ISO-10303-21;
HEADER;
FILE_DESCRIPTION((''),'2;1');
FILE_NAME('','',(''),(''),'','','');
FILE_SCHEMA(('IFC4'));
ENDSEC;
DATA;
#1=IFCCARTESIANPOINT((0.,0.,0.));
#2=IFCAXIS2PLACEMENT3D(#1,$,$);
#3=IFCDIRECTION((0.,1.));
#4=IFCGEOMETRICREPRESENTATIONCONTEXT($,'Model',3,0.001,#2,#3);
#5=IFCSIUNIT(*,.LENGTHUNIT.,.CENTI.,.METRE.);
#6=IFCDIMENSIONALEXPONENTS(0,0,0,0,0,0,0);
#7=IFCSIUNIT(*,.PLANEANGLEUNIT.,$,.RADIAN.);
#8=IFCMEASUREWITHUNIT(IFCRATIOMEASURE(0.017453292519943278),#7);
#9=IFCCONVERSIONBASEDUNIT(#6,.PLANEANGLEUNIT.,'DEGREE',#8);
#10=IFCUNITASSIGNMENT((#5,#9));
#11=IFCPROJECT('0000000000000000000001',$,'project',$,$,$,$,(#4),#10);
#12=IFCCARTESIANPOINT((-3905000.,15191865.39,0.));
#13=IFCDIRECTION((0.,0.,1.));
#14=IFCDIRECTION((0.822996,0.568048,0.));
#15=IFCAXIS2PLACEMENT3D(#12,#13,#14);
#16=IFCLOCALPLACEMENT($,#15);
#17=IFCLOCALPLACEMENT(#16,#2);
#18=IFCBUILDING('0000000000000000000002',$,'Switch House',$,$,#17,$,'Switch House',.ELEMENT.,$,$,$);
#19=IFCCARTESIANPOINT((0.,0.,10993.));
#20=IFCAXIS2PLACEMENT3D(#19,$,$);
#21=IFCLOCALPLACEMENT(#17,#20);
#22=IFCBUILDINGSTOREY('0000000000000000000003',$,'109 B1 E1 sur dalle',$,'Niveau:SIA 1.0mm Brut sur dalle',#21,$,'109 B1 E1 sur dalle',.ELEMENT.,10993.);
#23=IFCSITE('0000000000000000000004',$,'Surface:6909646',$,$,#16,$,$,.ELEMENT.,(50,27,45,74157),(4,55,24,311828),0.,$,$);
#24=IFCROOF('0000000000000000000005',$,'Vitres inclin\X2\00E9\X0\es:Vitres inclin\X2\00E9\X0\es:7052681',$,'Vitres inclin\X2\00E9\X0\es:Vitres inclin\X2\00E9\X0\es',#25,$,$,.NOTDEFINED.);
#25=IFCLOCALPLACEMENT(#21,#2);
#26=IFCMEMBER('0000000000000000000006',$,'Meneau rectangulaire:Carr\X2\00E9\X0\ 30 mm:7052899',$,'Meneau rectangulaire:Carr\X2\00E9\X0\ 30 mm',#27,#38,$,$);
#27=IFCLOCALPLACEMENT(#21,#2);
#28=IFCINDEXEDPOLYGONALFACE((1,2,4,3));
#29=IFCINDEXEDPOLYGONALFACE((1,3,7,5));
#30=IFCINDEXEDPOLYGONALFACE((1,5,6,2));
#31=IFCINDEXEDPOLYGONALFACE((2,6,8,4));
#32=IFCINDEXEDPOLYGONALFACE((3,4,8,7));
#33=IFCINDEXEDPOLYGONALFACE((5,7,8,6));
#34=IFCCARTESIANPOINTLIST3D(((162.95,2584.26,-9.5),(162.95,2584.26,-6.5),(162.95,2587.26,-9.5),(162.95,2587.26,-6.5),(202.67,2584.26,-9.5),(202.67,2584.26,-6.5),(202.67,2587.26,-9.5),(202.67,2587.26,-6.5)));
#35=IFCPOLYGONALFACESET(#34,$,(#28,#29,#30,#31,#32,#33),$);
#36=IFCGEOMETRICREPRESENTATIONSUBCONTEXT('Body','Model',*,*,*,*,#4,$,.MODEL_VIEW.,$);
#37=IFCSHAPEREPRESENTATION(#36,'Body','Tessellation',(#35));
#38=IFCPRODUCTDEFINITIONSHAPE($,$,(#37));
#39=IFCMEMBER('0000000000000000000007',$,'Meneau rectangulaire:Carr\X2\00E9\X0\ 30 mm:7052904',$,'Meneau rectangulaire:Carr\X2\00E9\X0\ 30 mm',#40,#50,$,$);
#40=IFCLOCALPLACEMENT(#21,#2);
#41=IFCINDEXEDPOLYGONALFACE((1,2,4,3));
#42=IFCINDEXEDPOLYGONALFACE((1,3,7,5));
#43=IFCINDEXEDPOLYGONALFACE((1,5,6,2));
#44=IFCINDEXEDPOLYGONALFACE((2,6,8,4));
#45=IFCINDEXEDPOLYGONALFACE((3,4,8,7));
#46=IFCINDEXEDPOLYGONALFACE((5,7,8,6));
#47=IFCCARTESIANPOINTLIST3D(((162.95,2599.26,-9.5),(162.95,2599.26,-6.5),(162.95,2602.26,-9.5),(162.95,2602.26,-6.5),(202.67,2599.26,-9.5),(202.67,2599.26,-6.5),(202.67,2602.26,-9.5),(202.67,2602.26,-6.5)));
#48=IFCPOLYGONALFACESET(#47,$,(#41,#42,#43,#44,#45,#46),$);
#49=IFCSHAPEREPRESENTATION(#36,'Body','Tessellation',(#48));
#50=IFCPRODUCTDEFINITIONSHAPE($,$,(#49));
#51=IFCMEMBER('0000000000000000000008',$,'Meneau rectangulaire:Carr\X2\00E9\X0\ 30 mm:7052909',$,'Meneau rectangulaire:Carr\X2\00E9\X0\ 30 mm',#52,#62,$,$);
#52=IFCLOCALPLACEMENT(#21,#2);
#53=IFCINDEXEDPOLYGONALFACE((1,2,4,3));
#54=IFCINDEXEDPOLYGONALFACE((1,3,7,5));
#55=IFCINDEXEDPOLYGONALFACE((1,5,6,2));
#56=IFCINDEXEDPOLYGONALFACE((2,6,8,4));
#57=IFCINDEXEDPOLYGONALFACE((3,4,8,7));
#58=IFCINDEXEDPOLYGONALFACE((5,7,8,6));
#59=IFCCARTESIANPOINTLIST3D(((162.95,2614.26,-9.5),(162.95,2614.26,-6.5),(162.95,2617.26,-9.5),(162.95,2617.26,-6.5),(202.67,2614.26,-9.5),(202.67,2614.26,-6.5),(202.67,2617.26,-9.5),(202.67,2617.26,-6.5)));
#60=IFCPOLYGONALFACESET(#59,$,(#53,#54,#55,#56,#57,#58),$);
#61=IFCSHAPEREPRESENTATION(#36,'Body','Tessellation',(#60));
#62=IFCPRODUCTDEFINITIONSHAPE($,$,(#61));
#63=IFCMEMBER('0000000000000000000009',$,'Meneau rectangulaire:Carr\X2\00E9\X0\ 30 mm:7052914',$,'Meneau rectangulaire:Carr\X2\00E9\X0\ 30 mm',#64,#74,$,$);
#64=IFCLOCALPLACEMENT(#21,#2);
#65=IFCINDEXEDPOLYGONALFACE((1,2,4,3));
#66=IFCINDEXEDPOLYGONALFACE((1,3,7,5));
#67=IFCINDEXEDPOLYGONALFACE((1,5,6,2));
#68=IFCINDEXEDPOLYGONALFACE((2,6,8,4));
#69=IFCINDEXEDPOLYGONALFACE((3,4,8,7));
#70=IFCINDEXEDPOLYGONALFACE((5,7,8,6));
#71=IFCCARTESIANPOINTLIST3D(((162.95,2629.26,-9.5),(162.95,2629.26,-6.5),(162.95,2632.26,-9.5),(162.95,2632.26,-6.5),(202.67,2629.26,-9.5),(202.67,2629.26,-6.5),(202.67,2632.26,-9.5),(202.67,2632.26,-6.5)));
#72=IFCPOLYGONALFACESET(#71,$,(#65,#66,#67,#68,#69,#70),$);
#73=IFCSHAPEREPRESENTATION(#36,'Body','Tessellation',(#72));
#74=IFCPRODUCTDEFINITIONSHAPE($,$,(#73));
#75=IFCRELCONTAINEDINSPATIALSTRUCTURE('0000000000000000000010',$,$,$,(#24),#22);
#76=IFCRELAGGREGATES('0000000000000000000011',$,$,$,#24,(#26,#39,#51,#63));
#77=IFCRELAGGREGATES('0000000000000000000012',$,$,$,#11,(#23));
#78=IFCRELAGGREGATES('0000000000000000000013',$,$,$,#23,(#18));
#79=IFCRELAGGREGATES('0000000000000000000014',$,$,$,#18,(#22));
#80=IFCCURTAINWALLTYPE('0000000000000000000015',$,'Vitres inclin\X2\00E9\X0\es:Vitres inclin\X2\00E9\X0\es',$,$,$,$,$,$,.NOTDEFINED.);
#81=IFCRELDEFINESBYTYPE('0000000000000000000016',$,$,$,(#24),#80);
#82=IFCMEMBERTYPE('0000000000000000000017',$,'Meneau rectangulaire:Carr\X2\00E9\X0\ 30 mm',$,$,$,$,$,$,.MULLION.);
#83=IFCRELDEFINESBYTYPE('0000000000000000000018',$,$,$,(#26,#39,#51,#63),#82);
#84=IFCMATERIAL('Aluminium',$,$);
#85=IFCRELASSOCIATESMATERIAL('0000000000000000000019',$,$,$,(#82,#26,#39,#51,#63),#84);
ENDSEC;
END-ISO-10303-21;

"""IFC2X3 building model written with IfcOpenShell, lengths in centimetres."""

from ifc_helpers import new_model, entity, si_unit, converted_unit, direction, frame, origin, origin_2d_with_axis, place, context, subcontext, project, spatial, rectangle, extrude, source, transform, mapped, material, type_object, type_shapes, element, aggregate, save


model = new_model("IFC2X3")

# Units and contexts
model_context = context("Model", 3, precision=0.001, world=origin(), true_north=direction((0.0, 1.0)))
body_context = subcontext(model_context, "Body", "Model", "MODEL_VIEW")
ifc_project = project(units=[si_unit("LENGTHUNIT", "METRE", prefix="CENTI"), converted_unit("PLANEANGLEUNIT", "DEGREE", entity("IfcRatioMeasure", 0.017453292519943278), si_unit("PLANEANGLEUNIT", "RADIAN"), dimensions=[0, 0, 0, 0, 0, 0, 0])], contexts=[model_context])

# Site, building, storey
site_placement = place(None, frame((-3905000.0, 15191865.39, 0.0), z_axis=(0.0, 0.0, 1.0), x_axis=(0.822996, 0.568048, 0.0)))
site = spatial("IfcSite", under=ifc_project, at=site_placement, Name="Surface:6909646", CompositionType="ELEMENT", RefLatitude=(50, 27, 45, 74157), RefLongitude=(4, 55, 24, 311828), RefElevation=0.0)
building_placement = place(site_placement, origin())
building = spatial("IfcBuilding", under=site, at=building_placement, Name="Switch House", LongName="Switch House", CompositionType="ELEMENT")
storey_placement = place(building_placement, frame((0.0, 0.0, 10993.0)))
storey = spatial("IfcBuildingStorey", under=building, at=storey_placement, Name="109 B1 E1 sur dalle", ObjectType="Niveau:SIA 1.0mm Brut sur dalle", LongName="109 B1 E1 sur dalle", CompositionType="ELEMENT", Elevation=10993.0)

# Roof, members
curtain_wall_type = type_object("IfcCurtainWallType", Name="Vitres inclinées:Vitres inclinées", PredefinedType="NOTDEFINED")
roof_placement = place(storey_placement, frame((0.0, 0.0, -10993.0)))
roof = element("IfcRoof", 1, at=roof_placement, inside=storey, type_object=curtain_wall_type, Name="Vitres inclinées:Vitres inclinées:7052681", ObjectType="Vitres inclinées:Vitres inclinées", ShapeType="NOTDEFINED")
ifc_material = material(Name="Aluminium")
member_type_1 = type_object("IfcMemberType", Name="Meneau rectangulaire:Carré 30 mm", PredefinedType="MULLION", material=ifc_material)
shared_shape_1 = source(origin(), body_context, "Body", "SweptSolid", [
    extrude(rectangle(XDim=3.0, YDim=3.0, at=origin_2d_with_axis()), frame((0.0, 0.0, -39.72), z_axis=(0.0, 0.0, 1.0), x_axis=(0.0, -1.0, 0.0)), (0.0, 0.0, 1.0), 39.72),
])
type_shapes(member_type_1, [shared_shape_1])
member_1_placement = place(roof_placement, frame((162.95, 2585.76, 10985.0), z_axis=(-1.0, 0.0, 0.0), x_axis=(0.0, 1.0, 0.0)))
member_1 = element("IfcMember", 2, at=member_1_placement, type_object=member_type_1, material=ifc_material, Name="Meneau rectangulaire:Carré 30 mm:7052899", ObjectType="Meneau rectangulaire:Carré 30 mm", context=body_context, shape_type="MappedRepresentation", body=[
    mapped(shared_shape_1, transform((0.0, 0.0, 0.0), scale=1.0)),
])
member_2_placement = place(roof_placement, frame((162.95, 2600.76, 10985.0), z_axis=(-1.0, 0.0, 0.0), x_axis=(0.0, 1.0, 0.0)))
member_2 = element("IfcMember", 3, at=member_2_placement, type_object=member_type_1, material=ifc_material, Name="Meneau rectangulaire:Carré 30 mm:7052904", ObjectType="Meneau rectangulaire:Carré 30 mm", context=body_context, shape_type="MappedRepresentation", body=[
    mapped(shared_shape_1, transform((0.0, 0.0, 0.0), scale=1.0)),
])
member_3_placement = place(roof_placement, frame((162.95, 2615.76, 10985.0), z_axis=(-1.0, 0.0, 0.0), x_axis=(0.0, 1.0, 0.0)))
member_3 = element("IfcMember", 4, at=member_3_placement, type_object=member_type_1, material=ifc_material, Name="Meneau rectangulaire:Carré 30 mm:7052909", ObjectType="Meneau rectangulaire:Carré 30 mm", context=body_context, shape_type="MappedRepresentation", body=[
    mapped(shared_shape_1, transform((0.0, 0.0, 0.0), scale=1.0)),
])
member_4_placement = place(roof_placement, frame((162.95, 2630.76, 10985.0), z_axis=(-1.0, 0.0, 0.0), x_axis=(0.0, 1.0, 0.0)))
member_4 = element("IfcMember", 5, at=member_4_placement, type_object=member_type_1, material=ifc_material, Name="Meneau rectangulaire:Carré 30 mm:7052914", ObjectType="Meneau rectangulaire:Carré 30 mm", context=body_context, shape_type="MappedRepresentation", body=[
    mapped(shared_shape_1, transform((0.0, 0.0, 0.0), scale=1.0)),
])
aggregate(roof, [member_1, member_2, member_3, member_4])

save(model, "model.ifc")
